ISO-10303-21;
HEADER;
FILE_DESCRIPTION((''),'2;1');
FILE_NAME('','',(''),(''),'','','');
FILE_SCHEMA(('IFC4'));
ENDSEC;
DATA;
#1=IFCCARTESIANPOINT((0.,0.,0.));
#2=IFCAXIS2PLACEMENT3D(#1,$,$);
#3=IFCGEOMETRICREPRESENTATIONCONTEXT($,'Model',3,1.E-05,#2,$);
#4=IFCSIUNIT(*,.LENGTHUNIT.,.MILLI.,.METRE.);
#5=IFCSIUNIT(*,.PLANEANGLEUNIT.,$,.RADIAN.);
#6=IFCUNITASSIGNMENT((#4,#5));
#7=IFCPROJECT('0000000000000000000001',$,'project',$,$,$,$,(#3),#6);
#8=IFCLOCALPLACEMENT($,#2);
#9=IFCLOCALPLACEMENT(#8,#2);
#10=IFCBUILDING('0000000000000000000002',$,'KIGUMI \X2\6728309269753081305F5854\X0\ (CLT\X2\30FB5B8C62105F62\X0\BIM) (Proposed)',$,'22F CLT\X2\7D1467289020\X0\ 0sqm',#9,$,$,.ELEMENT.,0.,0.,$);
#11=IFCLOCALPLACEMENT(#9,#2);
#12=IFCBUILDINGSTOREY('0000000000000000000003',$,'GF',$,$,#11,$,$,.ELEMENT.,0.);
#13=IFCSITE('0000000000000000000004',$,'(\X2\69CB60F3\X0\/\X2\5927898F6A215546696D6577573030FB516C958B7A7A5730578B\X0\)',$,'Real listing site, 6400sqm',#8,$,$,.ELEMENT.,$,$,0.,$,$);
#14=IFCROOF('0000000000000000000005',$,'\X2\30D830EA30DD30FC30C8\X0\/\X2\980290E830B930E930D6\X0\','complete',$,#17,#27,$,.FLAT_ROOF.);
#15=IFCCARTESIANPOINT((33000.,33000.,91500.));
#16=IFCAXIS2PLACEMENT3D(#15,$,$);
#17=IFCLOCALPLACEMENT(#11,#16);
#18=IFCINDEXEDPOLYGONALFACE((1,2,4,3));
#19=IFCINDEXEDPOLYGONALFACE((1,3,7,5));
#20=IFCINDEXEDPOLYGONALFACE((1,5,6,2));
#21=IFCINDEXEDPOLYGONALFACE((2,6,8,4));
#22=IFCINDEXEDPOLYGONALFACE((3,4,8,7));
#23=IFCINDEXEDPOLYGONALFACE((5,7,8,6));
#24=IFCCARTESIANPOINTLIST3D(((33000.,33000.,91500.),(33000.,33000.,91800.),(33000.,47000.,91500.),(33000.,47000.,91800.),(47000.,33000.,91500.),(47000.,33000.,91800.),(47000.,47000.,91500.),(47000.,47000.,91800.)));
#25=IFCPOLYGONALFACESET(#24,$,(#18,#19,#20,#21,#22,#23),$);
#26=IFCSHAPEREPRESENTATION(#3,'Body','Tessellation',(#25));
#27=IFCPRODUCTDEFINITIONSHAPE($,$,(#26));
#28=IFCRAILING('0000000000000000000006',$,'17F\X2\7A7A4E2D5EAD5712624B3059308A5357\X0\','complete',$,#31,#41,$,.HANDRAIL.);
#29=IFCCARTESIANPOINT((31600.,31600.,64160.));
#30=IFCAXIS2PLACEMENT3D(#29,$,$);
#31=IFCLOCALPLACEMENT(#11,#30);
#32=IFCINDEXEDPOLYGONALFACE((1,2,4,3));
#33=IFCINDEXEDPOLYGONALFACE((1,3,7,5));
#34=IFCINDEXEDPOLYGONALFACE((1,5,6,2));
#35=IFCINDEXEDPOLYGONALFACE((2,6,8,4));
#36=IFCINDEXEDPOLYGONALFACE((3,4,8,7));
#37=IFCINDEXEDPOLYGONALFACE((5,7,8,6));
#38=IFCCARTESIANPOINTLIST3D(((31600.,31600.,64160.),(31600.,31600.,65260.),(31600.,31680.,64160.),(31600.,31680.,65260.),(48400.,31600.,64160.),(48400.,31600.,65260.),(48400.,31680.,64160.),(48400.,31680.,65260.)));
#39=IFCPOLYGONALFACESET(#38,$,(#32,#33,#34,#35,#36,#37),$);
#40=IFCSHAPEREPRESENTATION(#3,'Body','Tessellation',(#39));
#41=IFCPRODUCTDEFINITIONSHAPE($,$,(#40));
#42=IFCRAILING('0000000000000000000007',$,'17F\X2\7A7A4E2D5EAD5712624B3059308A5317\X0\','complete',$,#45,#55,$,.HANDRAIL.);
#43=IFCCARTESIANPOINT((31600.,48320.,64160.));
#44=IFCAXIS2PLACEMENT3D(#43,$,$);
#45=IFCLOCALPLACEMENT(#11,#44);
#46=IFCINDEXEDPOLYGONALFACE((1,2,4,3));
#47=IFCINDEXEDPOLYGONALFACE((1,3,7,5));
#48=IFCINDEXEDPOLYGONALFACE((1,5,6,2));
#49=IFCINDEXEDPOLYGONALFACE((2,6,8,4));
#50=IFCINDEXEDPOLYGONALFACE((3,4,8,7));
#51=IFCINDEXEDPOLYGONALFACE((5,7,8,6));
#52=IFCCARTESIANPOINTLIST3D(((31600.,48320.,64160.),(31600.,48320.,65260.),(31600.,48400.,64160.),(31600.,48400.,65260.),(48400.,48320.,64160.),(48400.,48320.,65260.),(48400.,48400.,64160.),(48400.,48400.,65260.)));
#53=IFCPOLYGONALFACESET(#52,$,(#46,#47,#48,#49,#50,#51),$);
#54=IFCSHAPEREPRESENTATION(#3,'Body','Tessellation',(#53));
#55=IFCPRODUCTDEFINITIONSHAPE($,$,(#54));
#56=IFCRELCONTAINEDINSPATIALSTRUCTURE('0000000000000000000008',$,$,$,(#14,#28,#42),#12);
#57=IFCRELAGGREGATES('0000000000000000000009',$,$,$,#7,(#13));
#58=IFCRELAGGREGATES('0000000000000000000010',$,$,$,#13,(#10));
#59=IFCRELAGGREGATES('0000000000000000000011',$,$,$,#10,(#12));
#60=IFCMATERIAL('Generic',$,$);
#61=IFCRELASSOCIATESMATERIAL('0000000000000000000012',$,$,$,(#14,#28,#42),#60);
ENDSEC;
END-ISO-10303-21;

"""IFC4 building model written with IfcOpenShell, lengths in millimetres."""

from ifc_helpers import new_model, si_unit, frame, frame_2d, origin, place, context, project, spatial, rectangle, extrude, material, element, save


model = new_model("IFC4")

# Units and contexts
model_context = context("Model", 3, precision=1e-05, world=origin())
ifc_project = project(units=[si_unit("LENGTHUNIT", "METRE", prefix="MILLI"), si_unit("PLANEANGLEUNIT", "RADIAN")], contexts=[model_context])

# Site, building, storey
site_placement = place(None, origin())
site = spatial("IfcSite", under=ifc_project, at=site_placement, Name="(構想/大規模商業敷地・公開空地型)", ObjectType="Real listing site, 6400sqm", CompositionType="ELEMENT", RefElevation=0.0)
building_placement = place(site_placement, origin())
building = spatial("IfcBuilding", under=site, at=building_placement, Name="KIGUMI 木を極めた塔 (CLT・完成形BIM) (Proposed)", ObjectType="22F CLT純木造 0sqm", CompositionType="ELEMENT", ElevationOfRefHeight=0.0, ElevationOfTerrain=0.0)
storey_placement = place(building_placement, origin())
storey = spatial("IfcBuildingStorey", under=building, at=storey_placement, Name="GF", CompositionType="ELEMENT", Elevation=0.0)

# Shared definitions
ifc_material = material(Name="Generic")

# Roof
roof_placement = place(storey_placement, frame((33000.0, 33000.0, 91500.0)))
element("IfcRoof", 1, at=roof_placement, inside=storey, material=ifc_material, Name="ヘリポート/頂部スラブ", Description="complete", PredefinedType="FLAT_ROOF", context=model_context, shape_type="SweptSolid", body=[
    extrude(rectangle(XDim=14000.0, YDim=14000.0, at=frame_2d((7000.0, 7000.0))), frame((33000.0, 33000.0, 91500.0)), (0.0, 0.0, 1.0), 300.0),
])

# Railings
railing_1_placement = place(storey_placement, frame((31600.0, 31600.0, 64160.0)))
element("IfcRailing", 2, at=railing_1_placement, inside=storey, material=ifc_material, Name="17F空中庭園手すり南", Description="complete", PredefinedType="HANDRAIL", context=model_context, shape_type="SweptSolid", body=[
    extrude(rectangle(XDim=16800.0, YDim=80.0, at=frame_2d((8400.0, 40.0))), frame((31600.0, 31600.0, 64160.0)), (0.0, 0.0, 1.0), 1100.0),
])
railing_2_placement = place(storey_placement, frame((31600.0, 48320.0, 64160.0)))
element("IfcRailing", 3, at=railing_2_placement, inside=storey, material=ifc_material, Name="17F空中庭園手すり北", Description="complete", PredefinedType="HANDRAIL", context=model_context, shape_type="SweptSolid", body=[
    extrude(rectangle(XDim=16800.0, YDim=80.0, at=frame_2d((8400.0, 40.0))), frame((31600.0, 48320.0, 64160.0)), (0.0, 0.0, 1.0), 1100.0),
])

save(model, "model.ifc")
